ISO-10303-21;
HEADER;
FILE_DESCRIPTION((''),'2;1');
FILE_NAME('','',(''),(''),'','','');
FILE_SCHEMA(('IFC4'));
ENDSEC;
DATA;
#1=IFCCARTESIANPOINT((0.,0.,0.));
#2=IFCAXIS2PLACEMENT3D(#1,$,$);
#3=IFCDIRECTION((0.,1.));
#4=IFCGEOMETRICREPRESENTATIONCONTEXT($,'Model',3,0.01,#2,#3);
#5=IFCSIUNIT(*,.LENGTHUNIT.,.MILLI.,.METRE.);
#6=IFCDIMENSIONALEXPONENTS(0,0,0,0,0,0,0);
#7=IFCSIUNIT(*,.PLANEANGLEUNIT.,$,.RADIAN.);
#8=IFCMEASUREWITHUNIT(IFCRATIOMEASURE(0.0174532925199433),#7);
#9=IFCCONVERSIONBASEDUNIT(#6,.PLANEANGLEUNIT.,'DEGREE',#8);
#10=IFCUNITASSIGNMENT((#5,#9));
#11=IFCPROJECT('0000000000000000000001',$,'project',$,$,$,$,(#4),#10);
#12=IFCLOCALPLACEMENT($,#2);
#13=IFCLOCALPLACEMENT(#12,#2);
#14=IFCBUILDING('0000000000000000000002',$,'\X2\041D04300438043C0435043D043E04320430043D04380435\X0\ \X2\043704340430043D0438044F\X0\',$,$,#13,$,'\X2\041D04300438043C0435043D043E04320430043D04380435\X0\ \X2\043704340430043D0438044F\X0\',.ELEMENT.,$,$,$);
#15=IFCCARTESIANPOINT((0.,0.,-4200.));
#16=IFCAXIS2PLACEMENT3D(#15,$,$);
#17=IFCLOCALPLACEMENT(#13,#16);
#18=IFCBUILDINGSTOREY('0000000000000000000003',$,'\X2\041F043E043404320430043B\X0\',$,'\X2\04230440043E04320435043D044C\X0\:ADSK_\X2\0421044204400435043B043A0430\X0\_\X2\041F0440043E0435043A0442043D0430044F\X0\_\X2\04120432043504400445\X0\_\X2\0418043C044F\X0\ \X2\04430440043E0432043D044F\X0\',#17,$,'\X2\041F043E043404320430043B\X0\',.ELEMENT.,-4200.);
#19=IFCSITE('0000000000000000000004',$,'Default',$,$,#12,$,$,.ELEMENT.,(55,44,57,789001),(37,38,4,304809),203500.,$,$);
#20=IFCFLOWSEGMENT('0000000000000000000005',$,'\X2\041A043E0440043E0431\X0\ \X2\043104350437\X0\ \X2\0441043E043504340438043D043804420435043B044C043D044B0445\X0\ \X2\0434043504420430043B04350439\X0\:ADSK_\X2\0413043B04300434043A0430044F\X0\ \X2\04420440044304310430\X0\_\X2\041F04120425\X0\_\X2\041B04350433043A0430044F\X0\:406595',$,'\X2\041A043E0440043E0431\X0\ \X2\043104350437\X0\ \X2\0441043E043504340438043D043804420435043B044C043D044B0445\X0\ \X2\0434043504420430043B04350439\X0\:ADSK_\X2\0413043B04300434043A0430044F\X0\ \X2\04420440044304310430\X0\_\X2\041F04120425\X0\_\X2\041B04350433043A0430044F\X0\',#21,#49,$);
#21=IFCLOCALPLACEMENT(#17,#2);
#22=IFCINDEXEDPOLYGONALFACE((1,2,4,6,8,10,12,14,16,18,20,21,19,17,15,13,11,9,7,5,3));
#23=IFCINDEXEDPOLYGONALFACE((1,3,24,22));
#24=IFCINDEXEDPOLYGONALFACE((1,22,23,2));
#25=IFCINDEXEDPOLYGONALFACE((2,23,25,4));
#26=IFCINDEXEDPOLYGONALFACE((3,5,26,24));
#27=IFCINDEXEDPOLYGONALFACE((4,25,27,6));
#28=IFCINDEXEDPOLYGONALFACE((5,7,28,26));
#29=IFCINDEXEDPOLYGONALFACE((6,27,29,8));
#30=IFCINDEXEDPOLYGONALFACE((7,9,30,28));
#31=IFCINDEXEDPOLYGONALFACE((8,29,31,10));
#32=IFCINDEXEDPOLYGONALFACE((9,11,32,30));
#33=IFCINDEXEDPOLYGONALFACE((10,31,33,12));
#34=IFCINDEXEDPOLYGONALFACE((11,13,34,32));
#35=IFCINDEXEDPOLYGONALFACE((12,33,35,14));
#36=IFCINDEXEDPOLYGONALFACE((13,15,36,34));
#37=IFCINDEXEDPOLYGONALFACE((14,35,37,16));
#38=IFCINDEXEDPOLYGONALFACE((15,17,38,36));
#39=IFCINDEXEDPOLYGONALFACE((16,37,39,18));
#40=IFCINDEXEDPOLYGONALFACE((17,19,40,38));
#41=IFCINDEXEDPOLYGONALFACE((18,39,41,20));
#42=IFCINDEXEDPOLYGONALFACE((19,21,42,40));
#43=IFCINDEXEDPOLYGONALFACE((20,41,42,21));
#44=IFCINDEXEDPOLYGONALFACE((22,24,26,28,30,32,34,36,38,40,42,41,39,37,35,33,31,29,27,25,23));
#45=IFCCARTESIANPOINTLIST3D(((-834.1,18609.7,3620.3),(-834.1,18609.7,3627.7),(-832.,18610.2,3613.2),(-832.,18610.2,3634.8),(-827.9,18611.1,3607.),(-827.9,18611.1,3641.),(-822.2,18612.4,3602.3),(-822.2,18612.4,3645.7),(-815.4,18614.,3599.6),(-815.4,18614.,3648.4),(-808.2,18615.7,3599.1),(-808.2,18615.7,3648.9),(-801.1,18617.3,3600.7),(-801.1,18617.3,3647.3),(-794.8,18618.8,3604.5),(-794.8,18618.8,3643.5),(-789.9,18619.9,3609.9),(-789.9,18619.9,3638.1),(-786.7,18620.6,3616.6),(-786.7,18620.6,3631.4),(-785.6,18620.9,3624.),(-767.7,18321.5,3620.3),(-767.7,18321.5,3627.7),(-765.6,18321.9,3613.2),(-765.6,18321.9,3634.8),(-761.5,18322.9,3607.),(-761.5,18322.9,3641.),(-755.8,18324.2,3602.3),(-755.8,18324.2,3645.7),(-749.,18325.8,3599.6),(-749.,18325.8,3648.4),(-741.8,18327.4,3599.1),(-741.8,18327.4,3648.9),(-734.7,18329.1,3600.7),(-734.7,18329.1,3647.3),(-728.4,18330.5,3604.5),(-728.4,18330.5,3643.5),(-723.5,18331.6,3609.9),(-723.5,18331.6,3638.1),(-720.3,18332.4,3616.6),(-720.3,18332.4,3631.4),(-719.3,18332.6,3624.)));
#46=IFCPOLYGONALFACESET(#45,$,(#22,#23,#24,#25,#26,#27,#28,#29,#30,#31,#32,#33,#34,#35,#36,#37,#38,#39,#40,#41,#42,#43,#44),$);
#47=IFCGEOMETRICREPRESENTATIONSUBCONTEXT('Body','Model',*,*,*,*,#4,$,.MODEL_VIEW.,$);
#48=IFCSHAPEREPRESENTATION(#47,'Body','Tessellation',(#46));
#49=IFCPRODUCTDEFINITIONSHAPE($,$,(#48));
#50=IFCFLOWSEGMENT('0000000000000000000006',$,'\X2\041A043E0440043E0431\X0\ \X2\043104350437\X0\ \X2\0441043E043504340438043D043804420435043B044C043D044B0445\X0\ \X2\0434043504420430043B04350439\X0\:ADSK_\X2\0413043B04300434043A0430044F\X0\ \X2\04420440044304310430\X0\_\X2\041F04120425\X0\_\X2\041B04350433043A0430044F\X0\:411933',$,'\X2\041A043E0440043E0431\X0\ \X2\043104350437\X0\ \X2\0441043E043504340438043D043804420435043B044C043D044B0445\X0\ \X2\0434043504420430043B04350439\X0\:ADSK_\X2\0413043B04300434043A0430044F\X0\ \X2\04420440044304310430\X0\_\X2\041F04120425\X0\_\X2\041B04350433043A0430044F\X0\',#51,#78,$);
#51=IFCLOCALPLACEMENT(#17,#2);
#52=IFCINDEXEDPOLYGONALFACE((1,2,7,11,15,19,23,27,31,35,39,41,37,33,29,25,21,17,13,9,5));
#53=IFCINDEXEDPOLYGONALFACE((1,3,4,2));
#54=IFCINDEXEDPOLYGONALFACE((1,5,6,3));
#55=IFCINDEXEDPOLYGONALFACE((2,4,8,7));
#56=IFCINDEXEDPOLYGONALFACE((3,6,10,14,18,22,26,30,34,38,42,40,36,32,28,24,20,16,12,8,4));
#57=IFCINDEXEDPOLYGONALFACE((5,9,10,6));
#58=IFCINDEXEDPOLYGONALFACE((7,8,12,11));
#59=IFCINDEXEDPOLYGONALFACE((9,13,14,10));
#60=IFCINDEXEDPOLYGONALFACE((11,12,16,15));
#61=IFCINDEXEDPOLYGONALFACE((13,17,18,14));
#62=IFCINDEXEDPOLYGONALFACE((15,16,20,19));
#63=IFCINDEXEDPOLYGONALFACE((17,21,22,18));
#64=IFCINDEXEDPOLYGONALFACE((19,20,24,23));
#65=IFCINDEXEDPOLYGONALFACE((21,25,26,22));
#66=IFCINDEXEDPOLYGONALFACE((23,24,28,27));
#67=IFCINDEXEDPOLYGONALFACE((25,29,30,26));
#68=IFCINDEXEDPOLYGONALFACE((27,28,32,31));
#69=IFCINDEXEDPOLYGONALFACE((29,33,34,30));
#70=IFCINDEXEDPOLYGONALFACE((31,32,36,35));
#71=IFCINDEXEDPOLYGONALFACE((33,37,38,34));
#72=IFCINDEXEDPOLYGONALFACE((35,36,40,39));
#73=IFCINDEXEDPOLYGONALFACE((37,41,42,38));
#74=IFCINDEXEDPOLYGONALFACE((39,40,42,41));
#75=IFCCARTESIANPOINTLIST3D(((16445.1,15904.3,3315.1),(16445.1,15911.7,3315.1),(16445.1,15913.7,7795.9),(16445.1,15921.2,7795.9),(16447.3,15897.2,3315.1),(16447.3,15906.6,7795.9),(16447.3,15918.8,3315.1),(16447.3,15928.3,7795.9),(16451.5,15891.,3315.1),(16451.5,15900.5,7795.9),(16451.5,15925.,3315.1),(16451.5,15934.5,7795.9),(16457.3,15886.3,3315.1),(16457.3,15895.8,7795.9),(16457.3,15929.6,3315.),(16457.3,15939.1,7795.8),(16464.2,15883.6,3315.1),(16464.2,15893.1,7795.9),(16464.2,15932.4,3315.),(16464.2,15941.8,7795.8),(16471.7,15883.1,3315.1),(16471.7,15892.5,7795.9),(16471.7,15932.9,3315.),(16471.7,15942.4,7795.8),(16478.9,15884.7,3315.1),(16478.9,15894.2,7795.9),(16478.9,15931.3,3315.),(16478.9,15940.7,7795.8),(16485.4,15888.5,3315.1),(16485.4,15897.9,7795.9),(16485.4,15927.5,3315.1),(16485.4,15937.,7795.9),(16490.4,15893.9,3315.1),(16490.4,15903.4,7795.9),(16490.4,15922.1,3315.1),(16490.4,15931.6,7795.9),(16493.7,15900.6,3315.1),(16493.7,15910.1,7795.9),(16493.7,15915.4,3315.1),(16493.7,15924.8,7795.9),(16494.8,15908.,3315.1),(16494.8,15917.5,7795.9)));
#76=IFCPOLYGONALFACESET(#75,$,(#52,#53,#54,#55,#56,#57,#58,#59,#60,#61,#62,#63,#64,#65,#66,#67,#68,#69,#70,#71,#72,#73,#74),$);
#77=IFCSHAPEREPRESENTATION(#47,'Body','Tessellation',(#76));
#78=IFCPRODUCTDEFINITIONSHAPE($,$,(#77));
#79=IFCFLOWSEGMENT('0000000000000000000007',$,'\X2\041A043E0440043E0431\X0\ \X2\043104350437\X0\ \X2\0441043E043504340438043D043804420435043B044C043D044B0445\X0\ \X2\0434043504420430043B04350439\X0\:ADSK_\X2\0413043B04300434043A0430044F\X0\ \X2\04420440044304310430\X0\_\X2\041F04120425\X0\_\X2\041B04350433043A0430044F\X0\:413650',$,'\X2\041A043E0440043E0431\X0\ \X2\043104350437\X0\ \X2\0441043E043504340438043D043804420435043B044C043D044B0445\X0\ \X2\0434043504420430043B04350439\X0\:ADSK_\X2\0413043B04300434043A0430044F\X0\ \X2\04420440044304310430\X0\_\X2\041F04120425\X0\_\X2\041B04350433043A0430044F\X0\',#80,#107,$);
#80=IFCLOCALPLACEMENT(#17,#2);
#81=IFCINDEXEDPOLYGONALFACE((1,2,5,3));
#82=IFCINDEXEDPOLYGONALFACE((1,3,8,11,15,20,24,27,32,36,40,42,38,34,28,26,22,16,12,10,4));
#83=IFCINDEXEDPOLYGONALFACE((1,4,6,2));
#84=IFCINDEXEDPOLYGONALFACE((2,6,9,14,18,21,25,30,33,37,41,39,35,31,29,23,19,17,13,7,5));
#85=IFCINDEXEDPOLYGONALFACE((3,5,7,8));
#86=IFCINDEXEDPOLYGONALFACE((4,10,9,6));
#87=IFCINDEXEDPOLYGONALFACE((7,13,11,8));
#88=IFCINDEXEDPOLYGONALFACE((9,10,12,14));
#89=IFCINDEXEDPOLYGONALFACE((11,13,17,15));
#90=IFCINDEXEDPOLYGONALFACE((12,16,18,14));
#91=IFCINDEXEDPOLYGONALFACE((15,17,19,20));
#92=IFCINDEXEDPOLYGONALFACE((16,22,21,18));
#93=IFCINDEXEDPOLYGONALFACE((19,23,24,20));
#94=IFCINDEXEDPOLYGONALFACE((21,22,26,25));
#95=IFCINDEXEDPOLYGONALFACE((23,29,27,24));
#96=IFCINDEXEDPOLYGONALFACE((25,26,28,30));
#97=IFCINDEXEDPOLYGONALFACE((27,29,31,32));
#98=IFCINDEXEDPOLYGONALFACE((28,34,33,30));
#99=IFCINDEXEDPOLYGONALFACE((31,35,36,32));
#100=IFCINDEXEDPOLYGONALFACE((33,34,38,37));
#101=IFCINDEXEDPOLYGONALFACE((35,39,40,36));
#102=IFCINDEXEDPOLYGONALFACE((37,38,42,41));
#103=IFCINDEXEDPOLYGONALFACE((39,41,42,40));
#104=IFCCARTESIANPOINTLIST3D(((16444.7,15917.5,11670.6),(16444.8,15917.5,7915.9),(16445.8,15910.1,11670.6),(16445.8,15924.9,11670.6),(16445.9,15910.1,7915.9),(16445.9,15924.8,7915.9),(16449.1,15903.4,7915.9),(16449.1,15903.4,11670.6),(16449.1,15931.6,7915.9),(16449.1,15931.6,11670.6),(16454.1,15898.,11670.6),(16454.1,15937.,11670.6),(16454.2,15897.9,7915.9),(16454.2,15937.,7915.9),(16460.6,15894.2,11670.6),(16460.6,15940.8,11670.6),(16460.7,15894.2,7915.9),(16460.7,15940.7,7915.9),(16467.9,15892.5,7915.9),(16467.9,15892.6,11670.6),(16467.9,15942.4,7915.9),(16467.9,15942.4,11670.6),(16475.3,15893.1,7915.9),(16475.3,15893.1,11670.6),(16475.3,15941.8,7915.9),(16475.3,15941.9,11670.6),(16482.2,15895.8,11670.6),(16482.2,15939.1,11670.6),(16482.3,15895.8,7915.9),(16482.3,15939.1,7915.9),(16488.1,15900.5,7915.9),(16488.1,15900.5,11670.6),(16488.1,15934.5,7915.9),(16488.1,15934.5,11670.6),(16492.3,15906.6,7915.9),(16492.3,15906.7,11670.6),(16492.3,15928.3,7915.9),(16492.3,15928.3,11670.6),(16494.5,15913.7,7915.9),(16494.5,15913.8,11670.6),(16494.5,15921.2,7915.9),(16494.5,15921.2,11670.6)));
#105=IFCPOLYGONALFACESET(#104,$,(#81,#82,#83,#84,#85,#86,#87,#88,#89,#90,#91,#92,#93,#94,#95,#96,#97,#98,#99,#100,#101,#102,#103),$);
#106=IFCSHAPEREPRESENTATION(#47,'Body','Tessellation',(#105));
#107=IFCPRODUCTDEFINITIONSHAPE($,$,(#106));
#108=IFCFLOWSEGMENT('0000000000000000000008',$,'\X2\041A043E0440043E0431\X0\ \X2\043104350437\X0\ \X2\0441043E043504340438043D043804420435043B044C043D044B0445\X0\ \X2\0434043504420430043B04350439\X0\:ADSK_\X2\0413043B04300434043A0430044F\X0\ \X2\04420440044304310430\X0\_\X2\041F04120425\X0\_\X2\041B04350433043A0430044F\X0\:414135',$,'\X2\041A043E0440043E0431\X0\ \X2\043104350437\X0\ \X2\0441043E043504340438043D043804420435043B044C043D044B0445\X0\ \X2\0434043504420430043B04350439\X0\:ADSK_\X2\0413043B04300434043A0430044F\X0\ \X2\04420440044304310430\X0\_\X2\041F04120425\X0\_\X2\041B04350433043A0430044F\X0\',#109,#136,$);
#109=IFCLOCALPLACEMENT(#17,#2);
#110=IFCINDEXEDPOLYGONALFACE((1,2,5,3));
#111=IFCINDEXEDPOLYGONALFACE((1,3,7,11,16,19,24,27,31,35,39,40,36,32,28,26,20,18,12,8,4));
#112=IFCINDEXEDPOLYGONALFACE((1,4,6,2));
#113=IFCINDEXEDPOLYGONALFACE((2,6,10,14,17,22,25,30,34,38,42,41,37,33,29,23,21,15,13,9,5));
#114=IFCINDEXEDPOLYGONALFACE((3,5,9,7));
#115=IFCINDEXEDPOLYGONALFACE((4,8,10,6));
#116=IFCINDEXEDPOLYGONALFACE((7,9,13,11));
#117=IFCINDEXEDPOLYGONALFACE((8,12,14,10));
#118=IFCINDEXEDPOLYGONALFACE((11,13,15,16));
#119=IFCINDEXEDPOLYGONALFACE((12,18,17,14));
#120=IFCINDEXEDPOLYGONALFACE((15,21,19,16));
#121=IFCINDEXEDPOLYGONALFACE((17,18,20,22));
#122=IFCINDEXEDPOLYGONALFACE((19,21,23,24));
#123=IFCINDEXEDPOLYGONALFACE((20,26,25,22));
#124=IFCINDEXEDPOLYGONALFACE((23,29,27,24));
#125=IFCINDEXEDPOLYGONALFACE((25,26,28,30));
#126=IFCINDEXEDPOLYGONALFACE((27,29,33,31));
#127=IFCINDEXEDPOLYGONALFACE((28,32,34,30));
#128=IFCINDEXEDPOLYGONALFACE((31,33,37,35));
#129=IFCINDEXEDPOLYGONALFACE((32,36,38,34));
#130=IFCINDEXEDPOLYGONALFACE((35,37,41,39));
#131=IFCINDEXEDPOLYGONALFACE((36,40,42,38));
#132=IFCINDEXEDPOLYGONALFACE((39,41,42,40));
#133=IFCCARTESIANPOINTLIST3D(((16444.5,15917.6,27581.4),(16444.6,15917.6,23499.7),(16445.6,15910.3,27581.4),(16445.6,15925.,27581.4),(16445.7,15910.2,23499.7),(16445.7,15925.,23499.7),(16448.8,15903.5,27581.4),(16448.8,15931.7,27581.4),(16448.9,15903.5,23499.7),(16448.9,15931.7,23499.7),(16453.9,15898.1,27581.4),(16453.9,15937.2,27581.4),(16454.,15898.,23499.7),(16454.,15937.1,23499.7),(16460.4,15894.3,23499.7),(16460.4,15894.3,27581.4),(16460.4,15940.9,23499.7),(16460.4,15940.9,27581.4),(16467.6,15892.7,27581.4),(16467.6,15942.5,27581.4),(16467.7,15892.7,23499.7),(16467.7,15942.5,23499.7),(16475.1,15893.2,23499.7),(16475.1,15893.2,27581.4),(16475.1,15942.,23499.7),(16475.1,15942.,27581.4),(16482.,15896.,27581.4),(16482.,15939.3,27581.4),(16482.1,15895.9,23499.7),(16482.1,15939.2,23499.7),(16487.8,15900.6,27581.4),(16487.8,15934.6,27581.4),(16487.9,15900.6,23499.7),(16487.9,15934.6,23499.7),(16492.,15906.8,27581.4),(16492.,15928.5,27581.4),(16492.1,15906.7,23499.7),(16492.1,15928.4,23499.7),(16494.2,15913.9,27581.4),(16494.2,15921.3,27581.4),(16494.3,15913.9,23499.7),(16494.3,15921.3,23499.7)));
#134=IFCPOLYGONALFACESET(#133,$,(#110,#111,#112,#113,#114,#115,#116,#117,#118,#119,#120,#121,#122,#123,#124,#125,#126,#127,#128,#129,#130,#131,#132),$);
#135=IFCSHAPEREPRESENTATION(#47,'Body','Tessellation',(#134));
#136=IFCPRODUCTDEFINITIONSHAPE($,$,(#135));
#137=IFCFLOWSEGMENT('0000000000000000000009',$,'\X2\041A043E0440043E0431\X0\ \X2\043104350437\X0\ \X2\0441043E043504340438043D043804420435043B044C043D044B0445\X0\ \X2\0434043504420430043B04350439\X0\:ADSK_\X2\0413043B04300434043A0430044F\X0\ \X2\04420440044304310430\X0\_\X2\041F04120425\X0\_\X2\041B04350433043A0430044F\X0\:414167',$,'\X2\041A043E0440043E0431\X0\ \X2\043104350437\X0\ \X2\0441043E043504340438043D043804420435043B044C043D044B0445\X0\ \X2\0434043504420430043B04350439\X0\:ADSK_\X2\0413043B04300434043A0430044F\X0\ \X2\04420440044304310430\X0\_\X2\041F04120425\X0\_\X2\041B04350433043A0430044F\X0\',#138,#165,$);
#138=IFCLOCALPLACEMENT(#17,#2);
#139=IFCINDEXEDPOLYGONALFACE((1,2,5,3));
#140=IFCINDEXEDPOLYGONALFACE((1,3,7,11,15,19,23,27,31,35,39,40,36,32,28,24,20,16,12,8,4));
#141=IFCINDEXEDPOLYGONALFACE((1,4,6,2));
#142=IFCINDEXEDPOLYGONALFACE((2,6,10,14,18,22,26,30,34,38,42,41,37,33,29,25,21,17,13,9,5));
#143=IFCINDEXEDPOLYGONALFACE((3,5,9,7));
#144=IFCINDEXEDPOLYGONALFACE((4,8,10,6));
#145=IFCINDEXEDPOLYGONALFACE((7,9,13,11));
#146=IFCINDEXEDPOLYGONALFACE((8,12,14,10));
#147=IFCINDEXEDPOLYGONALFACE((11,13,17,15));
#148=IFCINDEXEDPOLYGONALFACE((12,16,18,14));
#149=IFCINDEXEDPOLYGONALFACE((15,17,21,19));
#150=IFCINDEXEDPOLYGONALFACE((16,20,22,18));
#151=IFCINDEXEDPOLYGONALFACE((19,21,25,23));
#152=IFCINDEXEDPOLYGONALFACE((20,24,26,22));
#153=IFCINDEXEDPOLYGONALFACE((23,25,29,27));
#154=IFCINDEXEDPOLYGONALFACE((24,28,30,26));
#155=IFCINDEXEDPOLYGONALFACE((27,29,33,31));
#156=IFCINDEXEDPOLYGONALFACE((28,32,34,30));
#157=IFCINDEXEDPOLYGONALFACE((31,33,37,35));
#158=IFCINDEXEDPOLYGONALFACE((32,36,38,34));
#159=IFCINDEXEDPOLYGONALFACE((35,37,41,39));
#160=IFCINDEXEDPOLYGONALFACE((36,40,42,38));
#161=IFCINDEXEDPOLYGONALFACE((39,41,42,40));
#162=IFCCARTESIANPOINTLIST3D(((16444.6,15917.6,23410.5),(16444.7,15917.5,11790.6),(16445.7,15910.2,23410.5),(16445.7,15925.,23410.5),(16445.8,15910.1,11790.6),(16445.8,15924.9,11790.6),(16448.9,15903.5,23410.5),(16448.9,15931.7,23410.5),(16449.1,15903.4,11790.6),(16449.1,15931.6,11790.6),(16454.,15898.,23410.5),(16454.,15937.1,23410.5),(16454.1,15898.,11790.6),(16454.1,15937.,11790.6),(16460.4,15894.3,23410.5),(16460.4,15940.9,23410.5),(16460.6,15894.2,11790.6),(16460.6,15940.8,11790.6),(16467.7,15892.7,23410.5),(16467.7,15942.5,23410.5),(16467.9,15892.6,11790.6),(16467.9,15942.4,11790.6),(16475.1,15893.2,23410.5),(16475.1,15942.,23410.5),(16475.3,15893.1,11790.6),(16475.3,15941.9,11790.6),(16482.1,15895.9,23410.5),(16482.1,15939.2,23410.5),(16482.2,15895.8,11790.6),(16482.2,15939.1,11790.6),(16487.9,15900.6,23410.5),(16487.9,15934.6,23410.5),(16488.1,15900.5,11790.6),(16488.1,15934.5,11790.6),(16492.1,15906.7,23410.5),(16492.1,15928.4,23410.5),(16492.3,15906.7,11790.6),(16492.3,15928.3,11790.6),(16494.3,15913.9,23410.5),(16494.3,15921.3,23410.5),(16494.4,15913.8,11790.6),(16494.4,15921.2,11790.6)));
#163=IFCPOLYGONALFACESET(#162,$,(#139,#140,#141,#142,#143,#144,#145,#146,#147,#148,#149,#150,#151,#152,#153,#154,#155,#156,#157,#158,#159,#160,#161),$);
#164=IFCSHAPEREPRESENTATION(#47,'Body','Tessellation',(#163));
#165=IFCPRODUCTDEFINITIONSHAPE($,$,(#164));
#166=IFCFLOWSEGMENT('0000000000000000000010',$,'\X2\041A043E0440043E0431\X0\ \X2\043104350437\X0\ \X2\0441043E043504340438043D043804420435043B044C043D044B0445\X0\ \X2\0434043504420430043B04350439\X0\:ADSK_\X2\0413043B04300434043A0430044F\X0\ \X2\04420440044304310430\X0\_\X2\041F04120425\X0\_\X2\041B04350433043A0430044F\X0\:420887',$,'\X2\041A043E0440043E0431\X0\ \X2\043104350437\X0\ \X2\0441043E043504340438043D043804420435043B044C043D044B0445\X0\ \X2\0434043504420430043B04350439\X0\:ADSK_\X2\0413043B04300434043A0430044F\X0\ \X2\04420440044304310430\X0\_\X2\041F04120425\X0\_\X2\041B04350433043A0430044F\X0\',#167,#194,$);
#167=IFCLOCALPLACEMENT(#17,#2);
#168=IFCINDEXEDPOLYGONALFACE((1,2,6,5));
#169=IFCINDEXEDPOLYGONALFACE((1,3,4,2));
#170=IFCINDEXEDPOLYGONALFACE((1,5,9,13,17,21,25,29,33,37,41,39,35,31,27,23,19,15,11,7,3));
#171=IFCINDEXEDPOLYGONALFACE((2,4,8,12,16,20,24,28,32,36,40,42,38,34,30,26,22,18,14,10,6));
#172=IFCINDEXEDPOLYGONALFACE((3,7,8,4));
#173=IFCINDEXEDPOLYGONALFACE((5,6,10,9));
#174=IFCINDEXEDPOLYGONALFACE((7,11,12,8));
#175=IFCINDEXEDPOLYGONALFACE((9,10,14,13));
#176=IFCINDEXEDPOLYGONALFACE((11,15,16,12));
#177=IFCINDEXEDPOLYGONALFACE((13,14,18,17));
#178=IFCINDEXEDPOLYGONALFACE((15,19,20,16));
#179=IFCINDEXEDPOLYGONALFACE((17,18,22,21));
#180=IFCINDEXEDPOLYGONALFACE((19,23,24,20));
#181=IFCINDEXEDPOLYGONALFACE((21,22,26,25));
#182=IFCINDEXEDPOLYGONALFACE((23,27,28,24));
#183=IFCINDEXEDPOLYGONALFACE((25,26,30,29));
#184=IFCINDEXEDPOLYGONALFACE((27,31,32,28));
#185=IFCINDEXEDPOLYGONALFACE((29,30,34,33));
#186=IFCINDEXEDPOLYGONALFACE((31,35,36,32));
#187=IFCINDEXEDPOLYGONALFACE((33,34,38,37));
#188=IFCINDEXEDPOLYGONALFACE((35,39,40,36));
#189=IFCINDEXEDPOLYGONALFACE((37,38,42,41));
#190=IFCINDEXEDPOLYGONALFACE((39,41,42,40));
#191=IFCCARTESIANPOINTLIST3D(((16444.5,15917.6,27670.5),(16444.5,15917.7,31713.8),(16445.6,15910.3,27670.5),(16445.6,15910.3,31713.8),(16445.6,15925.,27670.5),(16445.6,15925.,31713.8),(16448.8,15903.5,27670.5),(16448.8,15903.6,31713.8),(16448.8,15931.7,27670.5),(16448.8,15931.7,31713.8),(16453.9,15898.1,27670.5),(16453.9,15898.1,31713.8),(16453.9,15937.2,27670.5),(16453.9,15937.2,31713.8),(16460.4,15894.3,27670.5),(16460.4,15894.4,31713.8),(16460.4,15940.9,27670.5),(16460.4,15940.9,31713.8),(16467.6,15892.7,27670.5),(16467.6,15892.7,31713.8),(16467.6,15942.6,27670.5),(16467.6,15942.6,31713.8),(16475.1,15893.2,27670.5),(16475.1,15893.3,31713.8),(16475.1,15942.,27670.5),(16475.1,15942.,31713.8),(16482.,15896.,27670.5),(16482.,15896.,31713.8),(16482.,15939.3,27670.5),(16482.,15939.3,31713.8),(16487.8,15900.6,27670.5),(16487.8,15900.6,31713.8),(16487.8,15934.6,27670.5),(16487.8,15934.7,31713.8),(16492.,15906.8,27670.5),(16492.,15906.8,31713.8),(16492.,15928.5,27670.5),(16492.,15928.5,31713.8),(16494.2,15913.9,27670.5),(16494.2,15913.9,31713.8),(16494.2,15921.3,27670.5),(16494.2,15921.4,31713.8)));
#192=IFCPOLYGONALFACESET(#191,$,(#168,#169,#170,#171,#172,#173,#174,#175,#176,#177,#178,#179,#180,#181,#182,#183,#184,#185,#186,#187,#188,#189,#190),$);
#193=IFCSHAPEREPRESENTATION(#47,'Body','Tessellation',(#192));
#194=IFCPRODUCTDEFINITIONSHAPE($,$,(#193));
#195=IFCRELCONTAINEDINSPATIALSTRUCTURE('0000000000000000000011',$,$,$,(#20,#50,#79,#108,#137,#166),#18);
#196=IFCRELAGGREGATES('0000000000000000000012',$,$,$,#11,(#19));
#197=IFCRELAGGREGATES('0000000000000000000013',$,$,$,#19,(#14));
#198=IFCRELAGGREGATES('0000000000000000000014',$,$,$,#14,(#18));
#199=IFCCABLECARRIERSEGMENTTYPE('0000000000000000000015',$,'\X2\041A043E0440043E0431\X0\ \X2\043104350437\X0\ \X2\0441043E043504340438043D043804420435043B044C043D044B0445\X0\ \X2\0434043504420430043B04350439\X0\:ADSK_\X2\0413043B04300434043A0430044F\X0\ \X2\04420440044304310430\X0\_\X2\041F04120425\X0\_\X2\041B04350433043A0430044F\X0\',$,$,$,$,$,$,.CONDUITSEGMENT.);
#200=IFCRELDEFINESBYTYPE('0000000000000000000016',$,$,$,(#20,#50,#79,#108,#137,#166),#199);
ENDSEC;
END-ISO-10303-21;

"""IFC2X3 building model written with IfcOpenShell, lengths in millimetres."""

from ifc_helpers import new_model, entity, si_unit, converted_unit, direction, frame, frame_2d, origin, origin_2d_with_axis, place, context, subcontext, project, spatial, circle, extrude, type_object, element, save


model = new_model("IFC2X3")

# Units and contexts
model_context = context("Model", 3, precision=0.01, world=origin(), true_north=direction((0.0, 1.0)))
body_context = subcontext(model_context, "Body", "Model", "MODEL_VIEW")
ifc_project = project(units=[si_unit("LENGTHUNIT", "METRE", prefix="MILLI"), converted_unit("PLANEANGLEUNIT", "DEGREE", entity("IfcRatioMeasure", 0.0174532925199433), si_unit("PLANEANGLEUNIT", "RADIAN"), dimensions=[0, 0, 0, 0, 0, 0, 0])], contexts=[model_context])

# Site, building, storey
site_placement = place(None, frame((0.0, 0.0, 0.0)))
site = spatial("IfcSite", under=ifc_project, at=site_placement, Name="Default", CompositionType="ELEMENT", RefLatitude=(55, 44, 57, 789001), RefLongitude=(37, 38, 4, 304809), RefElevation=203500.0)
building_placement = place(site_placement, origin())
building = spatial("IfcBuilding", under=site, at=building_placement, Name="Наименование здания", LongName="Наименование здания", CompositionType="ELEMENT")
storey_placement = place(building_placement, frame((0.0, 0.0, -4200.0)))
storey = spatial("IfcBuildingStorey", under=building, at=storey_placement, Name="Подвал", ObjectType="Уровень:ADSK_Стрелка_Проектная_Вверх_Имя уровня", LongName="Подвал", CompositionType="ELEMENT", Elevation=-4200.0)

# Flow segments
cable_carrier_segment_type_1 = type_object("IfcCableCarrierSegmentType", Name="Короб без соединительных деталей:ADSK_Гладкая труба_ПВХ_Легкая", PredefinedType="CONDUITSEGMENT")
flow_segment_1_placement = place(storey_placement, frame((-836.0, 18319.8, 3597.4)))
element("IfcFlowSegment", 1, at=flow_segment_1_placement, inside=storey, type_object=cable_carrier_segment_type_1, Name="Короб без соединительных деталей:ADSK_Гладкая труба_ПВХ_Легкая:406595", ObjectType="Короб без соединительных деталей:ADSK_Гладкая труба_ПВХ_Легкая", context=body_context, shape_type="SweptSolid", body=[
    extrude(circle(Radius=25.0, at=frame_2d((0.0, 0.0), x_axis=(1.0, 0.0))), frame((26.0, 295.5, 26.6), z_axis=(0.224428, -0.974491, 0.0), x_axis=(0.974491, 0.224428, 0.0)), (0.0, 0.0, 1.0), 295.8),
])
flow_segment_2_placement = place(storey_placement, frame((16443.2, 15881.4, 3315.0)))
element("IfcFlowSegment", 2, at=flow_segment_2_placement, inside=storey, type_object=cable_carrier_segment_type_1, Name="Короб без соединительных деталей:ADSK_Гладкая труба_ПВХ_Легкая:411933", ObjectType="Короб без соединительных деталей:ADSK_Гладкая труба_ПВХ_Легкая", context=body_context, shape_type="SweptSolid", body=[
    extrude(circle(Radius=25.0, at=origin_2d_with_axis()), frame((26.6, 26.6, 0.1), z_axis=(0.0, 0.002113, 0.999998), x_axis=(1.0, 0.0, 0.0)), (0.0, 0.0, 1.0), 4480.8),
])
flow_segment_3_placement = place(storey_placement, frame((16443.1, 15890.9, 7915.9)))
element("IfcFlowSegment", 3, at=flow_segment_3_placement, inside=storey, type_object=cable_carrier_segment_type_1, Name="Короб без соединительных деталей:ADSK_Гладкая труба_ПВХ_Легкая:413650", ObjectType="Короб без соединительных деталей:ADSK_Гладкая труба_ПВХ_Легкая", context=body_context, shape_type="SweptSolid", body=[
    extrude(circle(Radius=25.0, at=frame_2d((0.0, 0.0), x_axis=(1.0, 0.0))), frame((26.7, 26.6, 0.0), z_axis=(-0.000015, 0.000008, 1.0), x_axis=(-1.0, 0.0, -0.000015)), (0.0, 0.0, 1.0), 3754.7),
])
flow_segment_4_placement = place(storey_placement, frame((16442.9, 15891.0, 23499.7)))
element("IfcFlowSegment", 4, at=flow_segment_4_placement, inside=storey, type_object=cable_carrier_segment_type_1, Name="Короб без соединительных деталей:ADSK_Гладкая труба_ПВХ_Легкая:414135", ObjectType="Короб без соединительных деталей:ADSK_Гладкая труба_ПВХ_Легкая", context=body_context, shape_type="SweptSolid", body=[
    extrude(circle(Radius=25.0, at=origin_2d_with_axis()), frame((26.7, 26.6, 0.0), z_axis=(-0.000015, 0.000008, 1.0), x_axis=(-1.0, 0.0, -0.000015)), (0.0, 0.0, 1.0), 4081.7),
])
flow_segment_5_placement = place(storey_placement, frame((16443.0, 15890.9, 11790.6)))
element("IfcFlowSegment", 5, at=flow_segment_5_placement, inside=storey, type_object=cable_carrier_segment_type_1, Name="Короб без соединительных деталей:ADSK_Гладкая труба_ПВХ_Легкая:414167", ObjectType="Короб без соединительных деталей:ADSK_Гладкая труба_ПВХ_Легкая", context=body_context, shape_type="SweptSolid", body=[
    extrude(circle(Radius=25.0, at=origin_2d_with_axis()), frame((26.8, 26.6, 0.0), z_axis=(-0.000015, 0.000008, 1.0), x_axis=(-1.0, 0.0, -0.000015)), (0.0, 0.0, 1.0), 11620.0),
])
flow_segment_6_placement = place(storey_placement, frame((16442.9, 15891.0, 27670.5)))
element("IfcFlowSegment", 6, at=flow_segment_6_placement, inside=storey, type_object=cable_carrier_segment_type_1, Name="Короб без соединительных деталей:ADSK_Гладкая труба_ПВХ_Легкая:420887", ObjectType="Короб без соединительных деталей:ADSK_Гладкая труба_ПВХ_Легкая", context=body_context, shape_type="SweptSolid", body=[
    extrude(circle(Radius=25.0, at=origin_2d_with_axis()), frame((26.6, 26.6, 0.0), z_axis=(0.0, 0.000008, 1.0), x_axis=(-1.0, 0.0, 0.0)), (0.0, 0.0, 1.0), 4043.3),
])

save(model, "model.ifc")
